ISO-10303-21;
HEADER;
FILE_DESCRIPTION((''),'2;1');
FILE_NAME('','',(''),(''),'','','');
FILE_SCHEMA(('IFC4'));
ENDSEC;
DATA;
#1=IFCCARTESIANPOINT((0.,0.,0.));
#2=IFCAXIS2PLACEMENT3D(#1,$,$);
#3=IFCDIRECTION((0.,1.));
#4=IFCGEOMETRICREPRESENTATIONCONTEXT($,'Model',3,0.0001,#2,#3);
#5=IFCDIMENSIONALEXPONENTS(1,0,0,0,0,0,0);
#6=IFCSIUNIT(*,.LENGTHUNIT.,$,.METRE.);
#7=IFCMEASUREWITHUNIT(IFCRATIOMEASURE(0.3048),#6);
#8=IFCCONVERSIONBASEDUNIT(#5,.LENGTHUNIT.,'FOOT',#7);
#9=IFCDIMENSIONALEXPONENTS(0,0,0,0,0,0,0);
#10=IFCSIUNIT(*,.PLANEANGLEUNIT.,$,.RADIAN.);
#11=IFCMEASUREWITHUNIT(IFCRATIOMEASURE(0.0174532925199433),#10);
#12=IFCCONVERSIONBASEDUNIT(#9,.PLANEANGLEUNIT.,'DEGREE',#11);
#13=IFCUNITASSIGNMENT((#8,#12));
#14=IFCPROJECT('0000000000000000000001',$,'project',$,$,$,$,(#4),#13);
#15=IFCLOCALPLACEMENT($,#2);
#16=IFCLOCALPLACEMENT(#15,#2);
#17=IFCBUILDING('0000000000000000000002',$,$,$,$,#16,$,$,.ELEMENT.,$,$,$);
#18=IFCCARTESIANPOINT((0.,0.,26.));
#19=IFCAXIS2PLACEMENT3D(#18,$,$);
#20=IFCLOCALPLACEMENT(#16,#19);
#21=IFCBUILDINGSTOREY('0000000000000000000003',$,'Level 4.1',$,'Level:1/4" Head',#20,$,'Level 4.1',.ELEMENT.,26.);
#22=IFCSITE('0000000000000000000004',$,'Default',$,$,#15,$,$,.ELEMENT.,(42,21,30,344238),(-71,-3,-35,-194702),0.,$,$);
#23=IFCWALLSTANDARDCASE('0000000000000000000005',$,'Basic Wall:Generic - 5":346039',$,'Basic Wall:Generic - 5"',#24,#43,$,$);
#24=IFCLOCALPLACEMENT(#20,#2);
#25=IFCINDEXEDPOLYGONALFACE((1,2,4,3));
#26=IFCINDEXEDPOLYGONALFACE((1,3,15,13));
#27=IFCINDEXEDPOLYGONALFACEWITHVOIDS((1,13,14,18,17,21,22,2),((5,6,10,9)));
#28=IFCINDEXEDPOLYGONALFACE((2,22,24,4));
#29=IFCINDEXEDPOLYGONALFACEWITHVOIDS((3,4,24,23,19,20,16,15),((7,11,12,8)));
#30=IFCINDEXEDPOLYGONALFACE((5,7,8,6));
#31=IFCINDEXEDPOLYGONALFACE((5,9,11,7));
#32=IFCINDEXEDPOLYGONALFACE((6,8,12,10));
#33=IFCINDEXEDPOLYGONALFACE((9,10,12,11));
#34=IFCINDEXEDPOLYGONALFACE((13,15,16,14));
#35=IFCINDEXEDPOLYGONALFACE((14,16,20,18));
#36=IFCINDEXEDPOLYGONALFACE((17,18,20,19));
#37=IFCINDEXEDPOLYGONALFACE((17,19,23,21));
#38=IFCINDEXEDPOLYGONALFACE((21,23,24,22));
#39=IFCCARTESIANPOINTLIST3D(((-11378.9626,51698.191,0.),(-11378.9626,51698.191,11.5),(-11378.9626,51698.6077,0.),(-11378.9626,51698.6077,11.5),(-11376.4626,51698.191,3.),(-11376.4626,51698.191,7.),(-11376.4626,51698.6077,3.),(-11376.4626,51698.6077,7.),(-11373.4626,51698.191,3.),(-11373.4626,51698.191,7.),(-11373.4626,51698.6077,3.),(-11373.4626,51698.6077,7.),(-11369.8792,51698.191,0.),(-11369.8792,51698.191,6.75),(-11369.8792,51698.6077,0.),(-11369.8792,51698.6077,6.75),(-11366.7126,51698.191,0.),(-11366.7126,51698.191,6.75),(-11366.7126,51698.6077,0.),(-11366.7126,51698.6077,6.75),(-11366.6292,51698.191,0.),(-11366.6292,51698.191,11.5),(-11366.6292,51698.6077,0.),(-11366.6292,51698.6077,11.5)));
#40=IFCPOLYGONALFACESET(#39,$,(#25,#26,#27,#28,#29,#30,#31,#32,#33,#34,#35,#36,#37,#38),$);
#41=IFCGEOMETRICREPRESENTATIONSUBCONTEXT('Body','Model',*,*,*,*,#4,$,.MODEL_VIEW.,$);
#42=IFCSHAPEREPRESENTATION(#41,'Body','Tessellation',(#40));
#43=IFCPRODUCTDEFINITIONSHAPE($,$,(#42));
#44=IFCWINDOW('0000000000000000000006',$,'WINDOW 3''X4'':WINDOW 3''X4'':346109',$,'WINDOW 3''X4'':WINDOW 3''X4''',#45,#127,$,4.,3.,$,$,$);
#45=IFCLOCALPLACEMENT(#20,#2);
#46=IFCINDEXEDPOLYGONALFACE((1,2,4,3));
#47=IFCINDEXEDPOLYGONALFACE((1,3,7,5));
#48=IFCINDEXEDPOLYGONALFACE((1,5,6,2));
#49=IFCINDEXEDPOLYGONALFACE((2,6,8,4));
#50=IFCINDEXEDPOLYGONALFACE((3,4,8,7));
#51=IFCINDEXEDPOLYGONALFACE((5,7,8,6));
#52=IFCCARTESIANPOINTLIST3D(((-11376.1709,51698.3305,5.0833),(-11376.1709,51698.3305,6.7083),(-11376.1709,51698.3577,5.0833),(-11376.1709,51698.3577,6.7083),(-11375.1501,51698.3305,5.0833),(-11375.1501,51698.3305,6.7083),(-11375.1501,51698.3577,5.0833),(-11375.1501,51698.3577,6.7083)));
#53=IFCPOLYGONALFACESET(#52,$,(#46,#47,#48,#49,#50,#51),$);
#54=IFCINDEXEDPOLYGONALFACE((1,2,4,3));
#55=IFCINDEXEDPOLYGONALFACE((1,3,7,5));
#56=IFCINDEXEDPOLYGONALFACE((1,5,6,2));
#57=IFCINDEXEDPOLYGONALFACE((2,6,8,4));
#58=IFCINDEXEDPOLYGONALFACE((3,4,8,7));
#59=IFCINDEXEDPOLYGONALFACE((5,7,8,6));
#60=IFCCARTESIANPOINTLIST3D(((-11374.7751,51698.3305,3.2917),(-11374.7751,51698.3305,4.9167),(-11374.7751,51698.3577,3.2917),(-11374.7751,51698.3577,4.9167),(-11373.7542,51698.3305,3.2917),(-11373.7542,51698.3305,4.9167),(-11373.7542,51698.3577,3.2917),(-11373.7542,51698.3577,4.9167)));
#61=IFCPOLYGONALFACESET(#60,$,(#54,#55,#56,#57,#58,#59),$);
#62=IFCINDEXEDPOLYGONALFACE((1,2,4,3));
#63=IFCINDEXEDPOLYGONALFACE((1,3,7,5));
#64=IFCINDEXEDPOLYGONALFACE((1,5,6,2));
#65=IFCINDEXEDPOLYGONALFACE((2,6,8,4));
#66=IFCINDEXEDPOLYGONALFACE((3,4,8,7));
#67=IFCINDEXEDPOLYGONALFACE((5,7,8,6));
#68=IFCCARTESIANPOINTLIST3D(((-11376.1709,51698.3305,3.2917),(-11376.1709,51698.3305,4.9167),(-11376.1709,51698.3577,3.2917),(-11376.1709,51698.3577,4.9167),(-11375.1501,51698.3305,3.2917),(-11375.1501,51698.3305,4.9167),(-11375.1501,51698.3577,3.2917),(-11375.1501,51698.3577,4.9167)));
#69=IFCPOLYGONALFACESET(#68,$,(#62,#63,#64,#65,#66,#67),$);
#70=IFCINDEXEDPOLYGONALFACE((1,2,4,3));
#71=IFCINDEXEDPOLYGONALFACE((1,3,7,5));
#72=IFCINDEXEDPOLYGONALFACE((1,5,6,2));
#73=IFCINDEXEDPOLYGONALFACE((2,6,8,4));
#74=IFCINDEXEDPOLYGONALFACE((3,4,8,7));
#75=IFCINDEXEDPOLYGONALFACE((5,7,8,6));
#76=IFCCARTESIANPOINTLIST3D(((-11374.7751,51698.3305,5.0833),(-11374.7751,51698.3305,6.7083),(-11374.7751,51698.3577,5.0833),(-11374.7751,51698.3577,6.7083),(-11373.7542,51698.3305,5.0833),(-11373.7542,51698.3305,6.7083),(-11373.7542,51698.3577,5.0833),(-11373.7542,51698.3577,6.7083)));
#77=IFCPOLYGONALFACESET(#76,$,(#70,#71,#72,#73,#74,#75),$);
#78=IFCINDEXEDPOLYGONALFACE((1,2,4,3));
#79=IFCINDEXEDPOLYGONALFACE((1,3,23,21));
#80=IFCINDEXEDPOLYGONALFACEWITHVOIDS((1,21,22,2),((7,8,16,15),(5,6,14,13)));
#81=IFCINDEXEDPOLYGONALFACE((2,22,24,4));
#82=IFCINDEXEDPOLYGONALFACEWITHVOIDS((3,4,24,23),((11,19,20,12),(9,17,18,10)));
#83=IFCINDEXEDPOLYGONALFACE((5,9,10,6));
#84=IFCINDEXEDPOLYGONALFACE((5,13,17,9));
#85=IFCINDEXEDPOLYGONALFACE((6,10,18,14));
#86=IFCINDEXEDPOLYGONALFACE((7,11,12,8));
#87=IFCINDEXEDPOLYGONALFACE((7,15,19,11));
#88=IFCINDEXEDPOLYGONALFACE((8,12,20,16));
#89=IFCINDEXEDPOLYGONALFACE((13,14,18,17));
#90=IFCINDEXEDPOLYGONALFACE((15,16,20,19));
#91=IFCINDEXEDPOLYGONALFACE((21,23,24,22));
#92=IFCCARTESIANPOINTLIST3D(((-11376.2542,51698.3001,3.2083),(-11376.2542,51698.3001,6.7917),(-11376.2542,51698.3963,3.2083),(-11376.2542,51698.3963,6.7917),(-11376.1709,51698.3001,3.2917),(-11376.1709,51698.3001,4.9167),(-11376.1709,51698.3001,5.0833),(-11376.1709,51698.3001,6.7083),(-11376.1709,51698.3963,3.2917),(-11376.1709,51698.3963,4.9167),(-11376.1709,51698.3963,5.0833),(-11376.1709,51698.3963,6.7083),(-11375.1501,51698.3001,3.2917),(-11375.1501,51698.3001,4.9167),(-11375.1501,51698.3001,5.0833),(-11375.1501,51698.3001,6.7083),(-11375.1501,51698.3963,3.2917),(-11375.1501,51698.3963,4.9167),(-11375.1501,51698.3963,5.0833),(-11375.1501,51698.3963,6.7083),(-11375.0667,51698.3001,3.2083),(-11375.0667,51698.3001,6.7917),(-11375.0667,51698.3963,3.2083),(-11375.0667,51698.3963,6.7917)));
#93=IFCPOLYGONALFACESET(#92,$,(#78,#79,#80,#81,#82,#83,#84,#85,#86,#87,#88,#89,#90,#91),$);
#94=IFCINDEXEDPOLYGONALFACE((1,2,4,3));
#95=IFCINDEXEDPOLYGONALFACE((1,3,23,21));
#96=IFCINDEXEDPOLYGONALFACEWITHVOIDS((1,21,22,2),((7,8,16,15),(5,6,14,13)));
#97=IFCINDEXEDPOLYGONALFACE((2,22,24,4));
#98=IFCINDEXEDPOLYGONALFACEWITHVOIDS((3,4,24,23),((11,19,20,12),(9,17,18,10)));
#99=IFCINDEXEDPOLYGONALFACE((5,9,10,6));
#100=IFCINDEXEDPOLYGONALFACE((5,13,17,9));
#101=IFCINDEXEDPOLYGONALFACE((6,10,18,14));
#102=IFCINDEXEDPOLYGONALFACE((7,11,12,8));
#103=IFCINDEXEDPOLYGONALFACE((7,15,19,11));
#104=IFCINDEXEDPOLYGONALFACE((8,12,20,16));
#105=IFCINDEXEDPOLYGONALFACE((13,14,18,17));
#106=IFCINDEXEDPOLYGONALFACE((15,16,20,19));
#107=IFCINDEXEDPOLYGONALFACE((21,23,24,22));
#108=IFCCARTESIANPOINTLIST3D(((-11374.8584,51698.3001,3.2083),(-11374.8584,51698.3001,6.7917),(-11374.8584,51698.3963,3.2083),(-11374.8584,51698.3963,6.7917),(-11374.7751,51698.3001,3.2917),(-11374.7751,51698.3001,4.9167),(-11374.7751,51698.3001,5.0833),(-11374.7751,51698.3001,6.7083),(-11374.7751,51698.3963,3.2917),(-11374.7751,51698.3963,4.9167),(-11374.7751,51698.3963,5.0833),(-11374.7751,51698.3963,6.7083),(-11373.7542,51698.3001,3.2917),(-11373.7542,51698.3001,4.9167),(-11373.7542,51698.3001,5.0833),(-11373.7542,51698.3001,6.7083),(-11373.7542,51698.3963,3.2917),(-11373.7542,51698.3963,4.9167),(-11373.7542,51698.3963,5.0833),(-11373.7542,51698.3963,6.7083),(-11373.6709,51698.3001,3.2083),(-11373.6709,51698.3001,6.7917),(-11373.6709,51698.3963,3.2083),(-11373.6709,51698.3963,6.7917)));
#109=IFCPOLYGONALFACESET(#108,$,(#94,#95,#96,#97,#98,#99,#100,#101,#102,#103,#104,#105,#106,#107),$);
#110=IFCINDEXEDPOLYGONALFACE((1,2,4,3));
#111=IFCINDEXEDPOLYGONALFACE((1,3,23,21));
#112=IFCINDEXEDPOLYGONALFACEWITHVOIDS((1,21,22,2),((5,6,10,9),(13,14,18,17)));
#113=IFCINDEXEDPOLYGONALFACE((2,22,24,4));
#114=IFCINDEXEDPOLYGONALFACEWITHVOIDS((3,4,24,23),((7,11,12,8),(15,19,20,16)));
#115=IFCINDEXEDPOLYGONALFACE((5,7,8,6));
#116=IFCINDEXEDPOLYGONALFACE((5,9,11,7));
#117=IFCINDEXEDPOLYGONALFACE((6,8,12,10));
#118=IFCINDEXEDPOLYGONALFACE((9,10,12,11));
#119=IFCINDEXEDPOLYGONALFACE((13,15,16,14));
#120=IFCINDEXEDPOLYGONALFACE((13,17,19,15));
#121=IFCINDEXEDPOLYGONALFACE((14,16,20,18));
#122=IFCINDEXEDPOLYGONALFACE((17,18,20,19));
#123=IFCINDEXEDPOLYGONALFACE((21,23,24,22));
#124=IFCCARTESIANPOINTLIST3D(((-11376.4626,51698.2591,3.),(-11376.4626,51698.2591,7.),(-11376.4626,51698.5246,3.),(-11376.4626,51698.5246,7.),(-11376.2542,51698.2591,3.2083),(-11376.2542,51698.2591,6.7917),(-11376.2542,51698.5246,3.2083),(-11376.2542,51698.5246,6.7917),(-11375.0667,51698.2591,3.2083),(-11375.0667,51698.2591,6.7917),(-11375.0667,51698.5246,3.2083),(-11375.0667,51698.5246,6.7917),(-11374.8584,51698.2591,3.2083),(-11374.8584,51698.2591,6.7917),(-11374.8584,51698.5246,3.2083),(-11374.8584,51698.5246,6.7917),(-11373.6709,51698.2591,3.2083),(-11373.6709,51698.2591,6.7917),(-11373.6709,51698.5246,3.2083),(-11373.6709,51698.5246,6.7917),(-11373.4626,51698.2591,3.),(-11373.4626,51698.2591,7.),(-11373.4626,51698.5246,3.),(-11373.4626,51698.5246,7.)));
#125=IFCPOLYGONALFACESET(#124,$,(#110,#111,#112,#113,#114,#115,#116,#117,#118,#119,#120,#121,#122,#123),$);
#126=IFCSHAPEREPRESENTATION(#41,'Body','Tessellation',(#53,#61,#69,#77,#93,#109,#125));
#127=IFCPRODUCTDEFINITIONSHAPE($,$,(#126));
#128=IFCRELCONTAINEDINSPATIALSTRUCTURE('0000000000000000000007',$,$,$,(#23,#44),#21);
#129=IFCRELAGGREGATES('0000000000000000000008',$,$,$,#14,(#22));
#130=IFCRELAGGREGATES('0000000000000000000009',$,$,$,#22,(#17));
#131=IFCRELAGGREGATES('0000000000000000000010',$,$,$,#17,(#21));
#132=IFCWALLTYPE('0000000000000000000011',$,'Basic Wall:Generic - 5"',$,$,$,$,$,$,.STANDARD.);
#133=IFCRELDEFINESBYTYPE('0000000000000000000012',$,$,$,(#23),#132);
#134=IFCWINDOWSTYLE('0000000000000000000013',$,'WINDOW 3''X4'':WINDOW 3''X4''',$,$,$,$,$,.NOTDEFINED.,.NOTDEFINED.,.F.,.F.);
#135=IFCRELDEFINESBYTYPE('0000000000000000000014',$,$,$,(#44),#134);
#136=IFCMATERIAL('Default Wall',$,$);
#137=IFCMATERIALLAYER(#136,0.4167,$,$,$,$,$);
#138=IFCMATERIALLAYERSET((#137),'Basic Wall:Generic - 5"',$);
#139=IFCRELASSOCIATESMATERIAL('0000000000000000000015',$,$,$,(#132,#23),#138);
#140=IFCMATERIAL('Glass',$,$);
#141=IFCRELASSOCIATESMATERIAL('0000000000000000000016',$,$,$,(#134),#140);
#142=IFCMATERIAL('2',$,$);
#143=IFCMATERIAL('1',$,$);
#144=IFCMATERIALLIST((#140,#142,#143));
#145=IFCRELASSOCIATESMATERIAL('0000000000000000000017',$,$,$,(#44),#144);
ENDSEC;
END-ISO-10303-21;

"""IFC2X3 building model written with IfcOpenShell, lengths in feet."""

from ifc_helpers import new_model, entity, si_unit, converted_unit, direction, frame, frame_2d, origin, origin_2d_with_axis, place, context, subcontext, project, spatial, polyline, rectangle, outline, extrude, source, transform, mapped, material, material_list, layer, layer_set, layer_usage, type_object, type_shapes, element, fill, save


model = new_model("IFC2X3")

# Units and contexts
model_context = context("Model", 3, precision=0.0001, world=origin(), true_north=direction((0.0, 1.0)))
body_context = subcontext(model_context, "Body", "Model", "MODEL_VIEW")
ifc_project = project(units=[converted_unit("LENGTHUNIT", "FOOT", entity("IfcRatioMeasure", 0.3048), si_unit("LENGTHUNIT", "METRE"), dimensions=[1, 0, 0, 0, 0, 0, 0]), converted_unit("PLANEANGLEUNIT", "DEGREE", entity("IfcRatioMeasure", 0.0174532925199433), si_unit("PLANEANGLEUNIT", "RADIAN"), dimensions=[0, 0, 0, 0, 0, 0, 0])], contexts=[model_context])

# Site, building, storey
site_placement = place(None, origin())
site = spatial("IfcSite", under=ifc_project, at=site_placement, Name="Default", CompositionType="ELEMENT", RefLatitude=(42, 21, 30, 344238), RefLongitude=(-71, -3, -35, -194702), RefElevation=0.0)
building_placement = place(site_placement, origin())
building = spatial("IfcBuilding", under=site, at=building_placement, CompositionType="ELEMENT")
storey_placement = place(building_placement, frame((0.0, 0.0, 26.0)))
storey = spatial("IfcBuildingStorey", under=building, at=storey_placement, Name="Level 4.1", ObjectType="Level:1/4\" Head", LongName="Level 4.1", CompositionType="ELEMENT", Elevation=26.0)

# Shared definitions
ifc_material_1 = material(Name="Default Wall")
ifc_material_2 = material(Name="Glass")
ifc_material_3 = material(Name="2")
ifc_material_4 = material(Name="1")
ifc_layer_1 = layer(ifc_material_1, 0.4167)
ifc_layer_set_1 = layer_set([ifc_layer_1], Name="Basic Wall:Generic - 5\"")
wall_type_1 = type_object("IfcWallType", Name="Basic Wall:Generic - 5\"", PredefinedType="STANDARD", material=ifc_layer_set_1)

# Wall, openings, window
window_style_1 = type_object("IfcWindowStyle", Name="WINDOW 3'X4':WINDOW 3'X4'", ConstructionType="NOTDEFINED", OperationType="NOTDEFINED", ParameterTakesPrecedence=False, Sizeable=False, material=ifc_material_2)
shared_shape_1 = source(origin(), body_context, "Body", "SweptSolid", [
    extrude(rectangle(XDim=0.0272, YDim=1.0208, at=origin_2d_with_axis()), frame((2.1979, 0.2636, 2.0833), z_axis=(0.0, 0.0, 1.0), x_axis=(0.0, 1.0, 0.0)), (0.0, 0.0, 1.0), 1.625),
    extrude(rectangle(XDim=0.0272, YDim=1.0208, at=origin_2d_with_axis()), frame((0.8021, 0.2636, 0.2917), z_axis=(0.0, 0.0, 1.0), x_axis=(0.0, 1.0, 0.0)), (0.0, 0.0, 1.0), 1.625),
    extrude(rectangle(XDim=0.0272, YDim=1.0208, at=origin_2d_with_axis()), frame((2.1979, 0.2636, 0.2917), z_axis=(0.0, 0.0, 1.0), x_axis=(0.0, 1.0, 0.0)), (0.0, 0.0, 1.0), 1.625),
    extrude(rectangle(XDim=0.0272, YDim=1.0208, at=origin_2d_with_axis()), frame((0.8021, 0.2636, 2.0833), z_axis=(0.0, 0.0, 1.0), x_axis=(0.0, 1.0, 0.0)), (0.0, 0.0, 1.0), 1.625),
    extrude(outline(polyline([(-0.5938, -1.7917), (0.5938, -1.7917), (0.5938, 1.7917), (-0.5938, 1.7917), (-0.5938, -1.7917)]), holes=[polyline([(-0.5104, -0.0833), (0.5104, -0.0833), (0.5104, -1.7083), (-0.5104, -1.7083), (-0.5104, -0.0833)]), polyline([(-0.5104, 1.7083), (0.5104, 1.7083), (0.5104, 0.0833), (-0.5104, 0.0833), (-0.5104, 1.7083)])]), frame((2.1979, 0.2114, 2.0), z_axis=(0.0, 1.0, 0.0), x_axis=(-1.0, 0.0, 0.0)), (0.0, 0.0, 1.0), 0.0962),
    extrude(outline(polyline([(-1.7917, -0.5937), (1.7917, -0.5937), (1.7917, 0.5937), (-1.7917, 0.5937), (-1.7917, -0.5937)]), holes=[polyline([(0.0833, -0.5104), (0.0833, 0.5104), (1.7083, 0.5104), (1.7083, -0.5104), (0.0833, -0.5104)]), polyline([(-1.7083, -0.5104), (-1.7083, 0.5104), (-0.0833, 0.5104), (-0.0833, -0.5104), (-1.7083, -0.5104)])]), frame((0.8021, 0.2114, 2.0), z_axis=(0.0, 1.0, 0.0), x_axis=(0.0, 0.0, -1.0)), (0.0, 0.0, 1.0), 0.0962),
    extrude(outline(polyline([(-1.5, -2.0), (1.5, -2.0), (1.5, 2.0), (-1.5, 2.0), (-1.5, -2.0)]), holes=[polyline([(-0.1042, 1.7917), (-0.1042, -1.7917), (-1.2917, -1.7917), (-1.2917, 1.7917), (-0.1042, 1.7917)]), polyline([(0.1042, -1.7917), (0.1042, 1.7917), (1.2917, 1.7917), (1.2917, -1.7917), (0.1042, -1.7917)])]), frame((1.5, 0.0831, 2.0), z_axis=(0.0, 1.0, 0.0), x_axis=(1.0, 0.0, 0.0)), (0.0, 0.0, 1.0), 0.2655),
])
type_shapes(window_style_1, [shared_shape_1])
ifc_layer_usage_1 = layer_usage(ifc_layer_set_1, "AXIS2", "NEGATIVE", 0.2083)
wall_1_placement = place(storey_placement, frame((-11378.9626, 51698.3993, 0.0)))
wall_1 = element("IfcWallStandardCase", 1, at=wall_1_placement, inside=storey, type_object=wall_type_1, material=ifc_layer_usage_1, Name="Basic Wall:Generic - 5\":346039", ObjectType="Basic Wall:Generic - 5\"", context=body_context, shape_type="SweptSolid", body=[
    extrude(rectangle(XDim=12.3333, YDim=0.4167, at=frame_2d((6.1667, 0.0), x_axis=(-1.0, 0.0))), origin(), (0.0, 0.0, 1.0), 11.5),
])
opening_1_placement = place(wall_1_placement, frame((9.0833, -0.2083, 0.0)))
element("IfcOpeningElement", 2, at=opening_1_placement, cuts=wall_1, ObjectType="Opening", context=body_context, shape_type="SweptSolid", body=[
    extrude(rectangle(XDim=6.75, YDim=3.1667, at=frame_2d((3.375, 1.5833), x_axis=(1.0, 0.0))), frame((0.0, 0.0, 0.0), z_axis=(0.0, 1.0, 0.0), x_axis=(0.0, 0.0, 1.0)), (0.0, 0.0, 1.0), 0.4167),
])
opening_2_placement = place(wall_1_placement, frame((5.5, 0.2083, 3.0)))
opening_2 = element("IfcOpeningElement", 3, at=opening_2_placement, cuts=wall_1, ObjectType="Opening", context=body_context, shape_type="SweptSolid", body=[
    extrude(rectangle(XDim=4.0, YDim=3.0, at=frame_2d((2.0, 1.5), x_axis=(-1.0, 0.0))), frame((0.0, 0.0, 0.0), z_axis=(0.0, -1.0, 0.0), x_axis=(0.0, 0.0, 1.0)), (0.0, 0.0, 1.0), 0.4167),
])
ifc_material_list_1 = material_list([ifc_material_2, ifc_material_3, ifc_material_4])
window_1_placement = place(opening_2_placement, frame((0.0, 0.0, 0.0), z_axis=(0.0, 0.0, 1.0), x_axis=(-1.0, 0.0, 0.0)))
window_1 = element("IfcWindow", 4, at=window_1_placement, inside=storey, type_object=window_style_1, material=ifc_material_list_1, Name="WINDOW 3'X4':WINDOW 3'X4':346109", ObjectType="WINDOW 3'X4':WINDOW 3'X4'", OverallHeight=4.0, OverallWidth=3.0, context=body_context, shape_type="MappedRepresentation", body=[
    mapped(shared_shape_1, transform((0.0, 0.0, 0.0), scale=1.0)),
])
fill(opening_2, window_1)

save(model, "model.ifc")
